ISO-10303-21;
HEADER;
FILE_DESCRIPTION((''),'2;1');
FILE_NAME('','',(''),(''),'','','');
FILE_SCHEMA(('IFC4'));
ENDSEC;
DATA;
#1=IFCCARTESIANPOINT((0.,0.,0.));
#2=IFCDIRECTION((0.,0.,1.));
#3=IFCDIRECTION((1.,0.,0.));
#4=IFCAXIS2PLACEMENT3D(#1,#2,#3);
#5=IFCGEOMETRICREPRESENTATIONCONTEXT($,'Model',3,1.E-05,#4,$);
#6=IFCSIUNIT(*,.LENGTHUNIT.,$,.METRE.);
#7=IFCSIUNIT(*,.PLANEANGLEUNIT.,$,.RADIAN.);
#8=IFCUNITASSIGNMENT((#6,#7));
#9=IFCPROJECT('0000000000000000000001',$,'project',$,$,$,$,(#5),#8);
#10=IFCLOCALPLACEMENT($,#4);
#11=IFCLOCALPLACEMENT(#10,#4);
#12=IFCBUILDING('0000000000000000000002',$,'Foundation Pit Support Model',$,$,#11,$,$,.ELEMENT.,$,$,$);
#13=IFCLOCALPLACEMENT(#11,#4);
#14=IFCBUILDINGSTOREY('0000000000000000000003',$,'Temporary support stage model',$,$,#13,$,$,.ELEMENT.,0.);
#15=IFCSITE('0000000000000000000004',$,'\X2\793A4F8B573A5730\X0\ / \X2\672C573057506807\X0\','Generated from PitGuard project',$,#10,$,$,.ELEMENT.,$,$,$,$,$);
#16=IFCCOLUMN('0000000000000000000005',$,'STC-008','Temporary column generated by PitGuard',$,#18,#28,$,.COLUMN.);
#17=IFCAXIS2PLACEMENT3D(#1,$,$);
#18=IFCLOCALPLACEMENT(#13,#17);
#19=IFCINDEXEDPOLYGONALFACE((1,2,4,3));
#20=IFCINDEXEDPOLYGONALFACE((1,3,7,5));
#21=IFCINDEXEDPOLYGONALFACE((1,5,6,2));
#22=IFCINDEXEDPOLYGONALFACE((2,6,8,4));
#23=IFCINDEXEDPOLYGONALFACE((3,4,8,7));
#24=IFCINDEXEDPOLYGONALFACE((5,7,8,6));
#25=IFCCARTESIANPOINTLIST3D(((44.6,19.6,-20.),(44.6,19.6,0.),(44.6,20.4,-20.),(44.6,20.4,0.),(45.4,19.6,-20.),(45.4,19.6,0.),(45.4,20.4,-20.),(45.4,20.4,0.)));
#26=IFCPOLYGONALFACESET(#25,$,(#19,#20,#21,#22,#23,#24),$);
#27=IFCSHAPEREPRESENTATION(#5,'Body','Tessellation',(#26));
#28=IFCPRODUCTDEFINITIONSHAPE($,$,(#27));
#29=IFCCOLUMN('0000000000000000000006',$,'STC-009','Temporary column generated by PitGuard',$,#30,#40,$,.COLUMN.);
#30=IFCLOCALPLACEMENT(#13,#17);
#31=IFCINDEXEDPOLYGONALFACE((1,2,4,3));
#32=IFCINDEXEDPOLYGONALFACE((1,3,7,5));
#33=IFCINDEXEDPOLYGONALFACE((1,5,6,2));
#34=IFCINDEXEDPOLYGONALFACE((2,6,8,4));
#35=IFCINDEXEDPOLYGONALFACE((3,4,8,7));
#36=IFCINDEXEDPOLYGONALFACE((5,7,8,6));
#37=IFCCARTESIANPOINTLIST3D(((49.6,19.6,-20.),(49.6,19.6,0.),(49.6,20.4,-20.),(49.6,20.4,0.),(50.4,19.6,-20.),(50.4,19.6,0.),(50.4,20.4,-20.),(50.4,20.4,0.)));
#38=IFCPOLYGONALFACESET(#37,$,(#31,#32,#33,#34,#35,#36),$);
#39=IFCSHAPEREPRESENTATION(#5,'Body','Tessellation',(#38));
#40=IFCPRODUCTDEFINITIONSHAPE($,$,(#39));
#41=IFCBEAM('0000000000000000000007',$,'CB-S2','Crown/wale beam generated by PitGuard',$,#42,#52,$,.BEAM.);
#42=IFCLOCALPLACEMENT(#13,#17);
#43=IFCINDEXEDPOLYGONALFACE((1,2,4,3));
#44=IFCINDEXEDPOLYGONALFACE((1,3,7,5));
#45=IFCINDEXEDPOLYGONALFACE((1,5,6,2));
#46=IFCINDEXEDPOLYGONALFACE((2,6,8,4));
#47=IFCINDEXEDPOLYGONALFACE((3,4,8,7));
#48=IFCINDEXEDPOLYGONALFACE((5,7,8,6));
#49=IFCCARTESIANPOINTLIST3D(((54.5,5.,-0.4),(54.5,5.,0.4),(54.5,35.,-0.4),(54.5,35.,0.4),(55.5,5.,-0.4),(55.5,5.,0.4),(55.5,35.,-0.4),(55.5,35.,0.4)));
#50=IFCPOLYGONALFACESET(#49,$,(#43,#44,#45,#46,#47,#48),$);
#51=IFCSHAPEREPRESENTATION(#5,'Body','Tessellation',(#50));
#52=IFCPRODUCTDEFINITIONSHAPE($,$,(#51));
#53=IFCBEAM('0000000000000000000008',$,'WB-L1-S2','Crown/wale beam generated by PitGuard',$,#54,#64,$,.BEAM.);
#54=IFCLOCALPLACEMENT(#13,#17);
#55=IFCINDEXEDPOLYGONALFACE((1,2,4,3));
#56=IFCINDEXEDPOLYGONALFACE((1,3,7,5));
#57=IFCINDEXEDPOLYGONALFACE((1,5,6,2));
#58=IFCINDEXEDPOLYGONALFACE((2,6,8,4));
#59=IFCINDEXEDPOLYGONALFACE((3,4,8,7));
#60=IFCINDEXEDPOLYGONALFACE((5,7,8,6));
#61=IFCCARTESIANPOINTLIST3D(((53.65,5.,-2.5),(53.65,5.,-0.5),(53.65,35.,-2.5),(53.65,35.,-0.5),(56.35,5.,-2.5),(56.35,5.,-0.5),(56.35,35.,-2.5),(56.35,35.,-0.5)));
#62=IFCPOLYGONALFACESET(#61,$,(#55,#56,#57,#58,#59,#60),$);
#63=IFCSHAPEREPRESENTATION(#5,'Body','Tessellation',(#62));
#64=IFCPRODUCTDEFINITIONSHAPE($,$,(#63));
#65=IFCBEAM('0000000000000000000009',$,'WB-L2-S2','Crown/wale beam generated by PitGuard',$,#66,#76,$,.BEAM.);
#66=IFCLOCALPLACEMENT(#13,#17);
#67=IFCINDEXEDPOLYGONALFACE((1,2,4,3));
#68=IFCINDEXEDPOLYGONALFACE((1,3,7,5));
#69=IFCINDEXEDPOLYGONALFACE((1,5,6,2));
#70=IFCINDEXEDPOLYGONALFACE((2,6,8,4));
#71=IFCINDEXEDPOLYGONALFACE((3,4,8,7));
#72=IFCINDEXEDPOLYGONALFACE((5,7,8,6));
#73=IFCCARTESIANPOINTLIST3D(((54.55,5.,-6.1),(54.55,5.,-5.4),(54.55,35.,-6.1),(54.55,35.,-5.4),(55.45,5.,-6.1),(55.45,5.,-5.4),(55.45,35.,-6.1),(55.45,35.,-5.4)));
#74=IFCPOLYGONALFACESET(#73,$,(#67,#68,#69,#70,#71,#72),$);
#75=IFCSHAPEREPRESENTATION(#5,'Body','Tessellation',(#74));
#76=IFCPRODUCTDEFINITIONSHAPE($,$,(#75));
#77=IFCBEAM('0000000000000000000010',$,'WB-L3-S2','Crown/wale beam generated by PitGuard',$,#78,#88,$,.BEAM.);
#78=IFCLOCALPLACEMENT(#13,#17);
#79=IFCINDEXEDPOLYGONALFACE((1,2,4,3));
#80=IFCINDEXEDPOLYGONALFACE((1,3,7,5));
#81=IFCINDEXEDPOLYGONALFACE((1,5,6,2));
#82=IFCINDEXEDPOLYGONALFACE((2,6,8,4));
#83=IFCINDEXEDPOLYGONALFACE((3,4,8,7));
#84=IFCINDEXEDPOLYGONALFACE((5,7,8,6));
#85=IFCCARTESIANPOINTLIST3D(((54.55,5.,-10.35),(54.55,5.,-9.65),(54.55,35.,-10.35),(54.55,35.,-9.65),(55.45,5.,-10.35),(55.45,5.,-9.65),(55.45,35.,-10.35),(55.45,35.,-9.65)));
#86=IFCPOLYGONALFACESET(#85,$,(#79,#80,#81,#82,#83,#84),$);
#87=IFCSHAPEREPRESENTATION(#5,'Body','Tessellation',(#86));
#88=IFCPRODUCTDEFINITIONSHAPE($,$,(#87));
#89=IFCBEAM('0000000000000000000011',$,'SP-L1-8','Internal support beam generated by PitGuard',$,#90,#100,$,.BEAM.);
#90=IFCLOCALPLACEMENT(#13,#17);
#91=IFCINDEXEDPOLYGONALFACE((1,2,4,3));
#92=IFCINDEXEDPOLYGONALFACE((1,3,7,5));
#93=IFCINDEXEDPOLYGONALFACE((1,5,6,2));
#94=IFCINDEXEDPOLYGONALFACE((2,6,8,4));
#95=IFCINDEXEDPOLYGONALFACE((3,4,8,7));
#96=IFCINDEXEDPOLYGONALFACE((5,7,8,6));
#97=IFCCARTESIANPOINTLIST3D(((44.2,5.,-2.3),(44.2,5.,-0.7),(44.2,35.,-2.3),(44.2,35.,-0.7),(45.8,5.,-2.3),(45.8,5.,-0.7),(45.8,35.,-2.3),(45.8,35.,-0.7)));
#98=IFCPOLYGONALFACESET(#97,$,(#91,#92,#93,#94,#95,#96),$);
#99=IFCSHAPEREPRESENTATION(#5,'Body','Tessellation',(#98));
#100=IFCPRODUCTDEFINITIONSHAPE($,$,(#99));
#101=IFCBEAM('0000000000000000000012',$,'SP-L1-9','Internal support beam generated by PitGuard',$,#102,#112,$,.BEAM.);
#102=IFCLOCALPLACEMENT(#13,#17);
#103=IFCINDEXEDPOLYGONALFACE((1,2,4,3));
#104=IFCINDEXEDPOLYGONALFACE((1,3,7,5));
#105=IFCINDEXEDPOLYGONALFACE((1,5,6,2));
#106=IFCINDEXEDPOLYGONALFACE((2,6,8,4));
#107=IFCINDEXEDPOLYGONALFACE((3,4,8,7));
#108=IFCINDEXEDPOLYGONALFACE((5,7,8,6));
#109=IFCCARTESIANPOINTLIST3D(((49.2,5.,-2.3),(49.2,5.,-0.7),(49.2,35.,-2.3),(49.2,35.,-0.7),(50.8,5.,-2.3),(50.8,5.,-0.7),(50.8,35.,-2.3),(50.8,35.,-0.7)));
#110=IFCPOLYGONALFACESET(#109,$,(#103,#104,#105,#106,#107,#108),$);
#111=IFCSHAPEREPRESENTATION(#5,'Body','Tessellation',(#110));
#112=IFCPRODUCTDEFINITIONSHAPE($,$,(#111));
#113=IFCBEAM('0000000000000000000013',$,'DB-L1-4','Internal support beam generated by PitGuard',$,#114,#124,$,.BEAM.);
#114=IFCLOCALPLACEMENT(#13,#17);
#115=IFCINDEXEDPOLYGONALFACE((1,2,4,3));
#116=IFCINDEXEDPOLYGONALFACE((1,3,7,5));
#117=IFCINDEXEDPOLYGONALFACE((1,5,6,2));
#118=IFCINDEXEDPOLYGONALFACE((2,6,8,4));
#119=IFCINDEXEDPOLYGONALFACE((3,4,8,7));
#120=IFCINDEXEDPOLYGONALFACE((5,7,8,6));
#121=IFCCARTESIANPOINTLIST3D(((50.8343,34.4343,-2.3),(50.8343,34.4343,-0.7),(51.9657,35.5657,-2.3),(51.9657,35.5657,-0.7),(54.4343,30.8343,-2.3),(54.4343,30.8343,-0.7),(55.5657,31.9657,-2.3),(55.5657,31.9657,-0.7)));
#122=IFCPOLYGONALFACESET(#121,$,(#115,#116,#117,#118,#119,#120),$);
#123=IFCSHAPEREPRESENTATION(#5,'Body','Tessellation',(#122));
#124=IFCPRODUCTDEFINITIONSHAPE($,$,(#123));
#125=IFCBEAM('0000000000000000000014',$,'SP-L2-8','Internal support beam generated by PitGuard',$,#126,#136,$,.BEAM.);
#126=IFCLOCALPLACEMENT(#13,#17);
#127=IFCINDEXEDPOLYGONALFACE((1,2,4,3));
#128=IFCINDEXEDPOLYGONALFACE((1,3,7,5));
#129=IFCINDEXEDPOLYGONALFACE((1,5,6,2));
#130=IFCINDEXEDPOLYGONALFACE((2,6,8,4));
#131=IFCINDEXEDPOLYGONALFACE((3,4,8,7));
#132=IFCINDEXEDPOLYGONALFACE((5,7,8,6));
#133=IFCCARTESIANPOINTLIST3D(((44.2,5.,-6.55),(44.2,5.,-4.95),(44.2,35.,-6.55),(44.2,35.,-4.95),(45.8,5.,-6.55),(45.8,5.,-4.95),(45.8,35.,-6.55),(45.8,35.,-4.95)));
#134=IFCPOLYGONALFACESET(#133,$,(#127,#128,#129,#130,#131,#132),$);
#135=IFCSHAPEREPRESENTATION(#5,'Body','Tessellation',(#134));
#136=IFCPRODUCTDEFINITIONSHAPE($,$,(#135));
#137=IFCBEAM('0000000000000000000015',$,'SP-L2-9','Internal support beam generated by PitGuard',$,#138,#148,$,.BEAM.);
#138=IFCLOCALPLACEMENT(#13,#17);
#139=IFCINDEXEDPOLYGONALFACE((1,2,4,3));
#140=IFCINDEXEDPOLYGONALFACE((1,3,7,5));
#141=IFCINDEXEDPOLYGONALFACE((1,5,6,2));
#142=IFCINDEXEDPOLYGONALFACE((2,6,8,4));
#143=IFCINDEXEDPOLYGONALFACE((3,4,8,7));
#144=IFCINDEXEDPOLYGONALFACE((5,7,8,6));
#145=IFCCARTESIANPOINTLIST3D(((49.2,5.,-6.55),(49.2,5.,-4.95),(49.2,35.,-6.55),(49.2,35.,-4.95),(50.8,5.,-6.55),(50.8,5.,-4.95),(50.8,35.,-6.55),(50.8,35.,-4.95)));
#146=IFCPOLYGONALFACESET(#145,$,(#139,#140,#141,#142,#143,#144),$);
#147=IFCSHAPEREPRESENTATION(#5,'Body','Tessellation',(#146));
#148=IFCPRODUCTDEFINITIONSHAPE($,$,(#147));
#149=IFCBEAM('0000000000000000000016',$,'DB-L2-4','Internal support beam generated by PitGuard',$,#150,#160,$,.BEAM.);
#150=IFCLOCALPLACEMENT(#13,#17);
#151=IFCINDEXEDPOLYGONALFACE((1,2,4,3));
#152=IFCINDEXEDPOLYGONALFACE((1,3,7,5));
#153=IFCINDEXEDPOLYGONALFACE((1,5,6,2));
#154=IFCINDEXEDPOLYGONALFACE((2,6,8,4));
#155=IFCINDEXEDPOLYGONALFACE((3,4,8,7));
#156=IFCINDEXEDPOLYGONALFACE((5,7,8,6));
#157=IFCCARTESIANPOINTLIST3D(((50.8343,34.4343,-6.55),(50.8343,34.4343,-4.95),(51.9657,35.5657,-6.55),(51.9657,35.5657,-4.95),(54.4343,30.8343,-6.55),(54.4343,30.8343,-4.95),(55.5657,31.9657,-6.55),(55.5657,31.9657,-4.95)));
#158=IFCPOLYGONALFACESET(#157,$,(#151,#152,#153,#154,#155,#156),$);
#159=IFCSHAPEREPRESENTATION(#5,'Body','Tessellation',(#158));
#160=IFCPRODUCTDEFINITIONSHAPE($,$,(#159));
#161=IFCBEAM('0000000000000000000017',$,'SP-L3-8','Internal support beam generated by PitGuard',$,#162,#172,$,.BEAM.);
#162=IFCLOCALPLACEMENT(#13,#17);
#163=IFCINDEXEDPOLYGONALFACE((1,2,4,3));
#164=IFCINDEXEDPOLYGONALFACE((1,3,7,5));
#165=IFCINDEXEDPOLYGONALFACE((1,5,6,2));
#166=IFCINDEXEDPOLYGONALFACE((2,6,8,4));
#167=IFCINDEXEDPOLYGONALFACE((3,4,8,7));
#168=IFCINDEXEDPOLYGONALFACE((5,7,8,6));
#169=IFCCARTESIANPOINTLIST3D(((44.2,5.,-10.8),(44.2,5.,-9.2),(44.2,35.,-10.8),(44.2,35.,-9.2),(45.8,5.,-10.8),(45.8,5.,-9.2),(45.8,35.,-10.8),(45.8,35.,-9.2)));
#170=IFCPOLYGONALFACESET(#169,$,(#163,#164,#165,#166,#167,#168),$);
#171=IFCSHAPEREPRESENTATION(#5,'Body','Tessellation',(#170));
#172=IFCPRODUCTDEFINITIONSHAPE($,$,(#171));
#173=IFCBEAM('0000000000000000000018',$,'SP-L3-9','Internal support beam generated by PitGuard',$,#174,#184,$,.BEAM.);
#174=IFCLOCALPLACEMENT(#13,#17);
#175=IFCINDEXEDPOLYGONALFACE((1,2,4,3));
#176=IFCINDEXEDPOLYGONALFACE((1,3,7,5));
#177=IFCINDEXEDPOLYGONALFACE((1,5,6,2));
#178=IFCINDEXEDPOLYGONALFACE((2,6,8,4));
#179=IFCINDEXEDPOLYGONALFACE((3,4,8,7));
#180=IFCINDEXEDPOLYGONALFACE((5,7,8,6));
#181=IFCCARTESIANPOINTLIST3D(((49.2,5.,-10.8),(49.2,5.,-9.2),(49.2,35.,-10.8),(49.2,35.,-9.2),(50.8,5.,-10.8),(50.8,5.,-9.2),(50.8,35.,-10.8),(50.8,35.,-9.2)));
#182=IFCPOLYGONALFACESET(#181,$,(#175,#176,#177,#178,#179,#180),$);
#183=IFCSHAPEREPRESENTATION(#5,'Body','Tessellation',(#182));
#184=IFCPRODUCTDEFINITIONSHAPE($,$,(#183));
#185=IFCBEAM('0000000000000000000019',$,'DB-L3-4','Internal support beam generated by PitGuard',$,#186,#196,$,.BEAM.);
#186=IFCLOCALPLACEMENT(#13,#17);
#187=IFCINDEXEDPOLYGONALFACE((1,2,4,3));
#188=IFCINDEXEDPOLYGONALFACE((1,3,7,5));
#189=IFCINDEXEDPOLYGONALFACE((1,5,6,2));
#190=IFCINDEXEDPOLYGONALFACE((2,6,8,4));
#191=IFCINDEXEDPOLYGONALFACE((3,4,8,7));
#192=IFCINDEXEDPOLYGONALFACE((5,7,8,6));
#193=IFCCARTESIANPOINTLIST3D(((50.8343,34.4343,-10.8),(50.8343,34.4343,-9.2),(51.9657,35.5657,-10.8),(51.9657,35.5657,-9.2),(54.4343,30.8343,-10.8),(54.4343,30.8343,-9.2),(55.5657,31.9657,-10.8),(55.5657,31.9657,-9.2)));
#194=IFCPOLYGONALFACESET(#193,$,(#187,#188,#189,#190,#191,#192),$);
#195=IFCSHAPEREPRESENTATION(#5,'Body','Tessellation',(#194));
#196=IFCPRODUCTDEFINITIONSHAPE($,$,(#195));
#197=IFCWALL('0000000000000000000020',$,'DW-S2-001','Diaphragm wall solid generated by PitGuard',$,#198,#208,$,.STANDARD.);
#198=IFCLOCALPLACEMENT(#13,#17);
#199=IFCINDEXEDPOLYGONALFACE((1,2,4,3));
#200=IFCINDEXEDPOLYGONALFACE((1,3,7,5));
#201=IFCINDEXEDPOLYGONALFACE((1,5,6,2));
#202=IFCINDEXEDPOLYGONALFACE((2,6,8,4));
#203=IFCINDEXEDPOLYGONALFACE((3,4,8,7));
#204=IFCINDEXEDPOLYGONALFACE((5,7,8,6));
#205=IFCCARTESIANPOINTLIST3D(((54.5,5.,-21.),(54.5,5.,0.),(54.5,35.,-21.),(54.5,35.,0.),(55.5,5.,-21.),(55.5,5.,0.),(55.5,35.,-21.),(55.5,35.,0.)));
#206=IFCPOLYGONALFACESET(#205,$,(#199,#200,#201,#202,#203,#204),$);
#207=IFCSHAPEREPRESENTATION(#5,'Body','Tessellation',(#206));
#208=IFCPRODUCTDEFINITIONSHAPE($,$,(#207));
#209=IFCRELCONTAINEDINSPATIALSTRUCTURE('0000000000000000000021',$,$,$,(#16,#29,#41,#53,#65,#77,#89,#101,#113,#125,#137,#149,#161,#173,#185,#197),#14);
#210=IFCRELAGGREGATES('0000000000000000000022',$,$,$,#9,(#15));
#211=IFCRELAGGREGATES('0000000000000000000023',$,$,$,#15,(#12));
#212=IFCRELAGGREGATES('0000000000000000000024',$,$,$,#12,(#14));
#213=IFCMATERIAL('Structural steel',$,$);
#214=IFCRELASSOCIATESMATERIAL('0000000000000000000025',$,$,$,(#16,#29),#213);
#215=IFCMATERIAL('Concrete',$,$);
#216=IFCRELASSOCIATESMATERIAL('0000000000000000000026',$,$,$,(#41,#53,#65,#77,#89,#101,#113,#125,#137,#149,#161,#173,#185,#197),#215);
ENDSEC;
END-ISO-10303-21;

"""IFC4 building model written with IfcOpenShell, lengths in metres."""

from ifc_helpers import new_model, si_unit, frame, origin_with_axes, origin_2d, place, context, project, spatial, rectangle, extrude, material, element, save


model = new_model("IFC4")

# Units and contexts
model_context = context("Model", 3, precision=1e-05, world=origin_with_axes())
ifc_project = project(units=[si_unit("LENGTHUNIT", "METRE"), si_unit("PLANEANGLEUNIT", "RADIAN")], contexts=[model_context])

# Site, building, storey
site_placement = place(None, origin_with_axes())
site = spatial("IfcSite", under=ifc_project, at=site_placement, Name="示例场地 / 本地坐标", Description="Generated from PitGuard project", CompositionType="ELEMENT")
building_placement = place(site_placement, origin_with_axes())
building = spatial("IfcBuilding", under=site, at=building_placement, Name="Foundation Pit Support Model", CompositionType="ELEMENT")
storey_placement = place(building_placement, origin_with_axes())
storey = spatial("IfcBuildingStorey", under=building, at=storey_placement, Name="Temporary support stage model", CompositionType="ELEMENT", Elevation=0.0)

# Columns
ifc_material_1 = material(Name="Structural steel")
for number, where, z_axis, x_axis, name in (
    (1, (45.0, 20.0, -20.0), (0.0, 0.0, 1.0), (1.0, 0.0, 0.0), "STC-008"),
    (2, (50.0, 20.0, -20.0), (0.0, 0.0, 1.0), (1.0, 0.0, 0.0), "STC-009"),
):
    element("IfcColumn", number, at=place(storey_placement, frame(where, z_axis=z_axis, x_axis=x_axis)), inside=storey, material=ifc_material_1, Name=name, Description="Temporary column generated by PitGuard", PredefinedType="COLUMN", context=model_context, shape_type="SweptSolid", body=[
        extrude(rectangle(XDim=0.8, YDim=0.8, at=origin_2d()), origin_with_axes(), (0.0, 0.0, 1.0), 20.0),
    ])

# Beams
ifc_material_2 = material(Name="Concrete")
beam_1_placement = place(storey_placement, frame((55.0, 20.0, -0.4), z_axis=(0.0, 0.0, 1.0), x_axis=(0.0, 1.0, 0.0)))
element("IfcBeam", 3, at=beam_1_placement, inside=storey, material=ifc_material_2, Name="CB-S2", Description="Crown/wale beam generated by PitGuard", PredefinedType="BEAM", context=model_context, shape_type="SweptSolid", body=[
    extrude(rectangle(XDim=30.0, YDim=1.0, at=origin_2d()), origin_with_axes(), (0.0, 0.0, 1.0), 0.8),
])
beam_2_placement = place(storey_placement, frame((55.0, 20.0, -2.5), z_axis=(0.0, 0.0, 1.0), x_axis=(0.0, 1.0, 0.0)))
element("IfcBeam", 4, at=beam_2_placement, inside=storey, material=ifc_material_2, Name="WB-L1-S2", Description="Crown/wale beam generated by PitGuard", PredefinedType="BEAM", context=model_context, shape_type="SweptSolid", body=[
    extrude(rectangle(XDim=30.0, YDim=2.7, at=origin_2d()), origin_with_axes(), (0.0, 0.0, 1.0), 2.0),
])
for number, where, z_axis, x_axis, name in (
    (5, (55.0, 20.0, -6.1), (0.0, 0.0, 1.0), (0.0, 1.0, 0.0), "WB-L2-S2"),
    (6, (55.0, 20.0, -10.35), (0.0, 0.0, 1.0), (0.0, 1.0, 0.0), "WB-L3-S2"),
):
    element("IfcBeam", number, at=place(storey_placement, frame(where, z_axis=z_axis, x_axis=x_axis)), inside=storey, material=ifc_material_2, Name=name, Description="Crown/wale beam generated by PitGuard", PredefinedType="BEAM", context=model_context, shape_type="SweptSolid", body=[
        extrude(rectangle(XDim=30.0, YDim=0.9, at=origin_2d()), origin_with_axes(), (0.0, 0.0, 1.0), 0.7),
    ])
for number, where, z_axis, x_axis, name in (
    (7, (45.0, 20.0, -2.3), (0.0, 0.0, 1.0), (0.0, 1.0, 0.0), "SP-L1-8"),
    (8, (50.0, 20.0, -2.3), (0.0, 0.0, 1.0), (0.0, 1.0, 0.0), "SP-L1-9"),
):
    element("IfcBeam", number, at=place(storey_placement, frame(where, z_axis=z_axis, x_axis=x_axis)), inside=storey, material=ifc_material_2, Name=name, Description="Internal support beam generated by PitGuard", PredefinedType="BEAM", context=model_context, shape_type="SweptSolid", body=[
        extrude(rectangle(XDim=30.0, YDim=1.6, at=origin_2d()), origin_with_axes(), (0.0, 0.0, 1.0), 1.6),
    ])
beam_3_placement = place(storey_placement, frame((53.2, 33.2, -2.3), z_axis=(0.0, 0.0, 1.0), x_axis=(-0.707107, 0.707107, 0.0)))
element("IfcBeam", 9, at=beam_3_placement, inside=storey, material=ifc_material_2, Name="DB-L1-4", Description="Internal support beam generated by PitGuard", PredefinedType="BEAM", context=model_context, shape_type="SweptSolid", body=[
    extrude(rectangle(XDim=5.0912, YDim=1.6, at=origin_2d()), origin_with_axes(), (0.0, 0.0, 1.0), 1.6),
])
for number, where, z_axis, x_axis, name in (
    (10, (45.0, 20.0, -6.55), (0.0, 0.0, 1.0), (0.0, 1.0, 0.0), "SP-L2-8"),
    (11, (50.0, 20.0, -6.55), (0.0, 0.0, 1.0), (0.0, 1.0, 0.0), "SP-L2-9"),
):
    element("IfcBeam", number, at=place(storey_placement, frame(where, z_axis=z_axis, x_axis=x_axis)), inside=storey, material=ifc_material_2, Name=name, Description="Internal support beam generated by PitGuard", PredefinedType="BEAM", context=model_context, shape_type="SweptSolid", body=[
        extrude(rectangle(XDim=30.0, YDim=1.6, at=origin_2d()), origin_with_axes(), (0.0, 0.0, 1.0), 1.6),
    ])
beam_4_placement = place(storey_placement, frame((53.2, 33.2, -6.55), z_axis=(0.0, 0.0, 1.0), x_axis=(-0.707107, 0.707107, 0.0)))
element("IfcBeam", 12, at=beam_4_placement, inside=storey, material=ifc_material_2, Name="DB-L2-4", Description="Internal support beam generated by PitGuard", PredefinedType="BEAM", context=model_context, shape_type="SweptSolid", body=[
    extrude(rectangle(XDim=5.0912, YDim=1.6, at=origin_2d()), origin_with_axes(), (0.0, 0.0, 1.0), 1.6),
])
for number, where, z_axis, x_axis, name in (
    (13, (45.0, 20.0, -10.8), (0.0, 0.0, 1.0), (0.0, 1.0, 0.0), "SP-L3-8"),
    (14, (50.0, 20.0, -10.8), (0.0, 0.0, 1.0), (0.0, 1.0, 0.0), "SP-L3-9"),
):
    element("IfcBeam", number, at=place(storey_placement, frame(where, z_axis=z_axis, x_axis=x_axis)), inside=storey, material=ifc_material_2, Name=name, Description="Internal support beam generated by PitGuard", PredefinedType="BEAM", context=model_context, shape_type="SweptSolid", body=[
        extrude(rectangle(XDim=30.0, YDim=1.6, at=origin_2d()), origin_with_axes(), (0.0, 0.0, 1.0), 1.6),
    ])
beam_5_placement = place(storey_placement, frame((53.2, 33.2, -10.8), z_axis=(0.0, 0.0, 1.0), x_axis=(-0.707107, 0.707107, 0.0)))
element("IfcBeam", 15, at=beam_5_placement, inside=storey, material=ifc_material_2, Name="DB-L3-4", Description="Internal support beam generated by PitGuard", PredefinedType="BEAM", context=model_context, shape_type="SweptSolid", body=[
    extrude(rectangle(XDim=5.0912, YDim=1.6, at=origin_2d()), origin_with_axes(), (0.0, 0.0, 1.0), 1.6),
])

# Wall
wall_placement = place(storey_placement, frame((55.0, 20.0, -21.0), z_axis=(0.0, 0.0, 1.0), x_axis=(0.0, 1.0, 0.0)))
element("IfcWall", 16, at=wall_placement, inside=storey, material=ifc_material_2, Name="DW-S2-001", Description="Diaphragm wall solid generated by PitGuard", PredefinedType="STANDARD", context=model_context, shape_type="SweptSolid", body=[
    extrude(rectangle(XDim=30.0, YDim=1.0, at=origin_2d()), origin_with_axes(), (0.0, 0.0, 1.0), 21.0),
])

save(model, "model.ifc")
